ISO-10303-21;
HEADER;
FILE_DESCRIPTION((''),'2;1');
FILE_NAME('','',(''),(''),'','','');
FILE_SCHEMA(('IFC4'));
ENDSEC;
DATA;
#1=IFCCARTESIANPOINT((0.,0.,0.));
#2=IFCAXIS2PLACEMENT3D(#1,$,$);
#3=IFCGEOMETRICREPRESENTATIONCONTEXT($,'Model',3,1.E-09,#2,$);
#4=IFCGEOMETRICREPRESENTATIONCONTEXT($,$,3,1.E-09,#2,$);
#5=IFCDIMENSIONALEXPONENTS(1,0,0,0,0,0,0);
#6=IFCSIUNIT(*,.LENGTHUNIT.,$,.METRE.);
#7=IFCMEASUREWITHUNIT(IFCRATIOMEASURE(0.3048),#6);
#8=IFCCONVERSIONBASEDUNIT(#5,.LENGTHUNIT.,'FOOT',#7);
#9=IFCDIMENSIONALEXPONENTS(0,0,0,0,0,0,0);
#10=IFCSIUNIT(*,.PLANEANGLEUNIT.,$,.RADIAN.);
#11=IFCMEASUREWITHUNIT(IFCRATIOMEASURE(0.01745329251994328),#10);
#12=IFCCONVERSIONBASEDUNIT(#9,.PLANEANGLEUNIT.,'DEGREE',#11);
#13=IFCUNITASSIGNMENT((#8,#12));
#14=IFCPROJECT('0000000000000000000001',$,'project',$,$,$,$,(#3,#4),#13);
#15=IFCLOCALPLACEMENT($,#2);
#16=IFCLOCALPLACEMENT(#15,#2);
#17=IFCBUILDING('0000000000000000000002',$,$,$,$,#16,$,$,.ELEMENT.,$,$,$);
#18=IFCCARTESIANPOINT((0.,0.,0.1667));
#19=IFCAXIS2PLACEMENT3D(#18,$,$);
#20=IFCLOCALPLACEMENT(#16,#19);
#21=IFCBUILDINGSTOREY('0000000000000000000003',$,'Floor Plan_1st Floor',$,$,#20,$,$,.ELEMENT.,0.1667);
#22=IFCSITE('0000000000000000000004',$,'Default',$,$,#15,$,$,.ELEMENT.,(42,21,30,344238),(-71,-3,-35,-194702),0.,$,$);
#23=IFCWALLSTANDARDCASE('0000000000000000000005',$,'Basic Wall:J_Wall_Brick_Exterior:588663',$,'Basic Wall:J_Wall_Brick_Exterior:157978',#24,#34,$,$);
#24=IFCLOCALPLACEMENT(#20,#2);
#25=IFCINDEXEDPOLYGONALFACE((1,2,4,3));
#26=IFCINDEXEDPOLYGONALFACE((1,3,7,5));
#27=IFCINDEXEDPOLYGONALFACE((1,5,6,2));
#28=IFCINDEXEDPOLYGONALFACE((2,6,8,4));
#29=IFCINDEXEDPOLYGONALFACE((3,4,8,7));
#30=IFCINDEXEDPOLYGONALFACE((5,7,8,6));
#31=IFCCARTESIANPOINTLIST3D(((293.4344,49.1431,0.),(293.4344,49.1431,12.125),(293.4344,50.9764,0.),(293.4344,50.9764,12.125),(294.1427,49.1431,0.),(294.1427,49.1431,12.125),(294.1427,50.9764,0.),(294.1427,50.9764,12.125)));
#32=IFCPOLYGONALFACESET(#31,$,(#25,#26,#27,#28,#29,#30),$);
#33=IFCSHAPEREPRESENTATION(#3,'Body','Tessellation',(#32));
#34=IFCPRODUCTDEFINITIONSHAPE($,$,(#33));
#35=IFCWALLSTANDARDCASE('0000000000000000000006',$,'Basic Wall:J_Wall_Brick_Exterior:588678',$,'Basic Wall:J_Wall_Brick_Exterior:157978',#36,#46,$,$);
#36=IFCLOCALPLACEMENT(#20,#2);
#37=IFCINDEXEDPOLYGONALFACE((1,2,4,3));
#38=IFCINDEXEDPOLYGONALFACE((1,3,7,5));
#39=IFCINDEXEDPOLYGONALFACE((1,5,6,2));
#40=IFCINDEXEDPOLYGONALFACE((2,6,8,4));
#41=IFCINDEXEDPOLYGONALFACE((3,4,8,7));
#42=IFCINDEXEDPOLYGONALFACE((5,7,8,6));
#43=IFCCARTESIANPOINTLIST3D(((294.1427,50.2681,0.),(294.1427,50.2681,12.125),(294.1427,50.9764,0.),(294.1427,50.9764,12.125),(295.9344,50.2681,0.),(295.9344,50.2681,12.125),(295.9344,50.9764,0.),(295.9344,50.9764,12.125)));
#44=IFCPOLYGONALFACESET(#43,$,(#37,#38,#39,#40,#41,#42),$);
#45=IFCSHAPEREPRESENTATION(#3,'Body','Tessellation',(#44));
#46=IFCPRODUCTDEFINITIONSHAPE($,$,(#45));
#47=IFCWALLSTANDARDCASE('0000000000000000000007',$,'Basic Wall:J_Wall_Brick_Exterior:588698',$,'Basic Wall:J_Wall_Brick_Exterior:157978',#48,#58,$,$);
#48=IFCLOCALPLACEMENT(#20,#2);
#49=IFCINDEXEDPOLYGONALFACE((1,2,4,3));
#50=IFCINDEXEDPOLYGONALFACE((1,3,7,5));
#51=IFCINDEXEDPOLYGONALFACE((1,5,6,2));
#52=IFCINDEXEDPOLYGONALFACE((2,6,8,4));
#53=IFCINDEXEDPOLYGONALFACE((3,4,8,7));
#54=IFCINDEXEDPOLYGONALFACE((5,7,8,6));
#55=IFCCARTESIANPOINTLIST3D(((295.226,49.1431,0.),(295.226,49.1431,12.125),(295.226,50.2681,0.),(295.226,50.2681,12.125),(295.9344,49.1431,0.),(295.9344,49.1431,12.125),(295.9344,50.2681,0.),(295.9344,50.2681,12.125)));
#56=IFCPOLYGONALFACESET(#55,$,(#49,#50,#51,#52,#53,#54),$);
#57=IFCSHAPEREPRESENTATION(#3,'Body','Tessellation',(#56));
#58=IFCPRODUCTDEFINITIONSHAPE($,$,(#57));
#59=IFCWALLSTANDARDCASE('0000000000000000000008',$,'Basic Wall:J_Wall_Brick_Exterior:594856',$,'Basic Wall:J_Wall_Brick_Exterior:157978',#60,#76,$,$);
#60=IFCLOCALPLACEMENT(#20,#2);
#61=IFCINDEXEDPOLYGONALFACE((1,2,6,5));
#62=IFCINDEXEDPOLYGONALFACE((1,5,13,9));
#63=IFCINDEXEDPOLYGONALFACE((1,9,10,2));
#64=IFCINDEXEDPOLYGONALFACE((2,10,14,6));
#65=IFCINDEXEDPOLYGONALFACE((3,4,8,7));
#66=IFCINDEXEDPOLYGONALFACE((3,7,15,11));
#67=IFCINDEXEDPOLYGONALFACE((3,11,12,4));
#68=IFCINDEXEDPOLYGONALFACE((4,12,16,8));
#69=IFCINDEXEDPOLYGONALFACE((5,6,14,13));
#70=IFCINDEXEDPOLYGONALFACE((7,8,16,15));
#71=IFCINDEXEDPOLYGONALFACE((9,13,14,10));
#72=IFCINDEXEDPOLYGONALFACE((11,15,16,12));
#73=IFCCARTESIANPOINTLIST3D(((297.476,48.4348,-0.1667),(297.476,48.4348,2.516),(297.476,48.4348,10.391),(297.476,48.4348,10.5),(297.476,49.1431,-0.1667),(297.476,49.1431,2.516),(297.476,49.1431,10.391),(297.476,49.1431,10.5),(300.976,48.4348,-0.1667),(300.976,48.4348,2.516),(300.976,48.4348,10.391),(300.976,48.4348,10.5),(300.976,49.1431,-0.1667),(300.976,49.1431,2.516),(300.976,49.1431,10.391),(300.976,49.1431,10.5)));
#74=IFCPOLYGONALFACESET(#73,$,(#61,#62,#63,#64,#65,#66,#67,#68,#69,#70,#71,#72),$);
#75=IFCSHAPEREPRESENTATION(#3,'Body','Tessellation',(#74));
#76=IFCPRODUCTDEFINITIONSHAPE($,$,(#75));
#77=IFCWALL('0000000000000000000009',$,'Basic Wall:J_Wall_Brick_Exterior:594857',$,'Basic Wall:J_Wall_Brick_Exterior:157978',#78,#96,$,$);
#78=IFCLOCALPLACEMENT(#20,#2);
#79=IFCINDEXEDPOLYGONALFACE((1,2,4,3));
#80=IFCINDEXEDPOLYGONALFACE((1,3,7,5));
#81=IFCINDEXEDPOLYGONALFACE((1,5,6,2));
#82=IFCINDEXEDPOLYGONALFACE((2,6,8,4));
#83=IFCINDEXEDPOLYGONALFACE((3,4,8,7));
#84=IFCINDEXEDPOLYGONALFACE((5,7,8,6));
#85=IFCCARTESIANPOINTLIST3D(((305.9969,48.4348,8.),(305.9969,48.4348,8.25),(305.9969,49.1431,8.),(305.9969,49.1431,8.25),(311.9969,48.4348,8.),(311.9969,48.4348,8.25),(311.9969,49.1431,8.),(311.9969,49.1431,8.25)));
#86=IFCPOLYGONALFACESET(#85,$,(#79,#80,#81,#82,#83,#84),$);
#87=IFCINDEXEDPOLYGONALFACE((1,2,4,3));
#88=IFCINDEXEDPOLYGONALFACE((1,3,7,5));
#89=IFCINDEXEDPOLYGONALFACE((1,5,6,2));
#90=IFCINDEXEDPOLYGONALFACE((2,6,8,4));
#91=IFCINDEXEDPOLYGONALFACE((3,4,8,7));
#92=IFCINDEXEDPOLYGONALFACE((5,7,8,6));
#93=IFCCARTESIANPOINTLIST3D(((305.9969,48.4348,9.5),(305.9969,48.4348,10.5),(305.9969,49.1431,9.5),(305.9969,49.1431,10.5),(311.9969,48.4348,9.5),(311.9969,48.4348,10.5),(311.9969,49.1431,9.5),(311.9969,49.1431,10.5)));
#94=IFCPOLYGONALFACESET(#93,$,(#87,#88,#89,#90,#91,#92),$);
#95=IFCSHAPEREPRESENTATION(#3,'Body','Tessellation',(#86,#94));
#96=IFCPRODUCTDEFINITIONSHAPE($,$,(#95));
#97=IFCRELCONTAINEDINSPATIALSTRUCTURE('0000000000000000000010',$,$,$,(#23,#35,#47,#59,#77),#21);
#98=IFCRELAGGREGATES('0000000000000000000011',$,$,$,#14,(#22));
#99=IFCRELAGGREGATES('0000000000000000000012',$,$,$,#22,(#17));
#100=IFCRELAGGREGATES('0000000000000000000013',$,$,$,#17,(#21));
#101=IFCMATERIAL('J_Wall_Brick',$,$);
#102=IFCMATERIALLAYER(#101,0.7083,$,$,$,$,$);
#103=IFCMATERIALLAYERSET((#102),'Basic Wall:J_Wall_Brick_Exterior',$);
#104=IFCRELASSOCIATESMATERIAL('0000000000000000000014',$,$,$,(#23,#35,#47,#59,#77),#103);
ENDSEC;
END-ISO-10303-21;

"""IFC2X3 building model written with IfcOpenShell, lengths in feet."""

from ifc_helpers import new_model, entity, si_unit, converted_unit, frame, frame_2d, origin, origin_2d_with_axis, place, context, project, spatial, rectangle, extrude, clip, halfspace, material, layer, layer_set, layer_usage, element, save


model = new_model("IFC2X3")

# Units and contexts
model_context = context("Model", 3, precision=1e-09, world=origin())
context_of_model = context(None, 3, precision=1e-09, world=origin())
ifc_project = project(units=[converted_unit("LENGTHUNIT", "FOOT", entity("IfcRatioMeasure", 0.3048), si_unit("LENGTHUNIT", "METRE"), dimensions=[1, 0, 0, 0, 0, 0, 0]), converted_unit("PLANEANGLEUNIT", "DEGREE", entity("IfcRatioMeasure", 0.01745329251994328), si_unit("PLANEANGLEUNIT", "RADIAN"), dimensions=[0, 0, 0, 0, 0, 0, 0])], contexts=[model_context, context_of_model])

# Site, building, storey
site_placement = place(None, origin())
site = spatial("IfcSite", under=ifc_project, at=site_placement, Name="Default", CompositionType="ELEMENT", RefLatitude=(42, 21, 30, 344238), RefLongitude=(-71, -3, -35, -194702), RefElevation=0.0)
building_placement = place(site_placement, origin())
building = spatial("IfcBuilding", under=site, at=building_placement, CompositionType="ELEMENT")
storey_placement = place(building_placement, frame((0.0, 0.0, 0.1667)))
storey = spatial("IfcBuildingStorey", under=building, at=storey_placement, Name="Floor Plan_1st Floor", CompositionType="ELEMENT", Elevation=0.1667)

# Walls
ifc_material_1 = material(Name="J_Wall_Brick")
ifc_layer = layer(ifc_material_1, 0.7083)
ifc_layer_set = layer_set([ifc_layer], Name="Basic Wall:J_Wall_Brick_Exterior")
ifc_layer_usage_1 = layer_usage(ifc_layer_set, "AXIS2", "POSITIVE", -0.3542)
wall_1_placement = place(storey_placement, frame((293.7885, 49.1431, 0.0), z_axis=(0.0, 0.0, 1.0), x_axis=(0.0, 1.0, 0.0)))
element("IfcWallStandardCase", 1, at=wall_1_placement, inside=storey, material=ifc_layer_usage_1, Name="Basic Wall:J_Wall_Brick_Exterior:588663", ObjectType="Basic Wall:J_Wall_Brick_Exterior:157978", context=model_context, shape_type="Clipping", body=[
    clip(extrude(rectangle(XDim=1.8333, YDim=0.7083, at=frame_2d((0.9167, 0.0), x_axis=(-1.0, 0.0))), origin(), (0.0, 0.0, 1.0), 12.125), halfspace(origin(), True)),
])
ifc_layer_usage_2 = layer_usage(ifc_layer_set, "AXIS2", "POSITIVE", -0.3542)
wall_2_placement = place(storey_placement, frame((294.1427, 50.6223, 0.0)))
element("IfcWallStandardCase", 2, at=wall_2_placement, inside=storey, material=ifc_layer_usage_2, Name="Basic Wall:J_Wall_Brick_Exterior:588678", ObjectType="Basic Wall:J_Wall_Brick_Exterior:157978", context=model_context, shape_type="Clipping", body=[
    clip(extrude(rectangle(XDim=1.7917, YDim=0.7083, at=frame_2d((0.8958, 0.0), x_axis=(-1.0, 0.0))), origin(), (0.0, 0.0, 1.0), 12.125), halfspace(origin(), True)),
])
ifc_layer_usage_3 = layer_usage(ifc_layer_set, "AXIS2", "POSITIVE", -0.3542)
wall_3_placement = place(storey_placement, frame((295.5802, 50.2681, 0.0), z_axis=(0.0, 0.0, 1.0), x_axis=(0.0, -1.0, 0.0)))
element("IfcWallStandardCase", 3, at=wall_3_placement, inside=storey, material=ifc_layer_usage_3, Name="Basic Wall:J_Wall_Brick_Exterior:588698", ObjectType="Basic Wall:J_Wall_Brick_Exterior:157978", context=model_context, shape_type="Clipping", body=[
    clip(extrude(rectangle(XDim=1.125, YDim=0.7083, at=frame_2d((0.5625, 0.0), x_axis=(-1.0, 0.0))), origin(), (0.0, 0.0, 1.0), 12.125), halfspace(origin(), True)),
])

# Wall, opening
ifc_layer_usage_4 = layer_usage(ifc_layer_set, "AXIS2", "NEGATIVE", 0.3542)
wall_4_placement = place(storey_placement, frame((297.476, 48.7889, -0.1667)))
wall_4 = element("IfcWallStandardCase", 4, at=wall_4_placement, inside=storey, material=ifc_layer_usage_4, Name="Basic Wall:J_Wall_Brick_Exterior:594856", ObjectType="Basic Wall:J_Wall_Brick_Exterior:157978", context=model_context, shape_type="SweptSolid", body=[
    extrude(rectangle(XDim=3.5, YDim=0.7083, at=frame_2d((1.75, 0.0), x_axis=(-1.0, 0.0))), origin(), (0.0, 0.0, 1.0), 10.6667),
])
opening_placement = place(wall_4_placement, frame((0.0, -0.3542, 2.6827)))
element("IfcOpeningElement", 5, at=opening_placement, cuts=wall_4, ObjectType="Opening", context=model_context, shape_type="SweptSolid", body=[
    extrude(rectangle(XDim=3.5, YDim=7.875, at=frame_2d((3.9375, 1.75), x_axis=(0.0, -1.0))), frame((0.0, 0.0, 0.0), z_axis=(0.0, 1.0, 0.0), x_axis=(0.0, 0.0, 1.0)), (0.0, 0.0, 1.0), 0.7083),
])

# Wall
ifc_layer_usage_5 = layer_usage(ifc_layer_set, "AXIS2", "NEGATIVE", 0.3542)
wall_5_placement = place(storey_placement, frame((305.9969, 48.7889, 2.5833)))
element("IfcWall", 6, at=wall_5_placement, inside=storey, material=ifc_layer_usage_5, Name="Basic Wall:J_Wall_Brick_Exterior:594857", ObjectType="Basic Wall:J_Wall_Brick_Exterior:157978", context=model_context, shape_type="SweptSolid", body=[
    extrude(rectangle(XDim=0.7083, YDim=6.0, at=origin_2d_with_axis()), frame((3.0, 0.0, 5.4167), z_axis=(0.0, 0.0, 1.0), x_axis=(0.0, 1.0, 0.0)), (0.0, 0.0, 1.0), 0.25),
    extrude(rectangle(XDim=0.7083, YDim=6.0, at=origin_2d_with_axis()), frame((3.0, 0.0, 6.9167), z_axis=(0.0, 0.0, 1.0), x_axis=(0.0, 1.0, 0.0)), (0.0, 0.0, 1.0), 1.0),
])

save(model, "model.ifc")
